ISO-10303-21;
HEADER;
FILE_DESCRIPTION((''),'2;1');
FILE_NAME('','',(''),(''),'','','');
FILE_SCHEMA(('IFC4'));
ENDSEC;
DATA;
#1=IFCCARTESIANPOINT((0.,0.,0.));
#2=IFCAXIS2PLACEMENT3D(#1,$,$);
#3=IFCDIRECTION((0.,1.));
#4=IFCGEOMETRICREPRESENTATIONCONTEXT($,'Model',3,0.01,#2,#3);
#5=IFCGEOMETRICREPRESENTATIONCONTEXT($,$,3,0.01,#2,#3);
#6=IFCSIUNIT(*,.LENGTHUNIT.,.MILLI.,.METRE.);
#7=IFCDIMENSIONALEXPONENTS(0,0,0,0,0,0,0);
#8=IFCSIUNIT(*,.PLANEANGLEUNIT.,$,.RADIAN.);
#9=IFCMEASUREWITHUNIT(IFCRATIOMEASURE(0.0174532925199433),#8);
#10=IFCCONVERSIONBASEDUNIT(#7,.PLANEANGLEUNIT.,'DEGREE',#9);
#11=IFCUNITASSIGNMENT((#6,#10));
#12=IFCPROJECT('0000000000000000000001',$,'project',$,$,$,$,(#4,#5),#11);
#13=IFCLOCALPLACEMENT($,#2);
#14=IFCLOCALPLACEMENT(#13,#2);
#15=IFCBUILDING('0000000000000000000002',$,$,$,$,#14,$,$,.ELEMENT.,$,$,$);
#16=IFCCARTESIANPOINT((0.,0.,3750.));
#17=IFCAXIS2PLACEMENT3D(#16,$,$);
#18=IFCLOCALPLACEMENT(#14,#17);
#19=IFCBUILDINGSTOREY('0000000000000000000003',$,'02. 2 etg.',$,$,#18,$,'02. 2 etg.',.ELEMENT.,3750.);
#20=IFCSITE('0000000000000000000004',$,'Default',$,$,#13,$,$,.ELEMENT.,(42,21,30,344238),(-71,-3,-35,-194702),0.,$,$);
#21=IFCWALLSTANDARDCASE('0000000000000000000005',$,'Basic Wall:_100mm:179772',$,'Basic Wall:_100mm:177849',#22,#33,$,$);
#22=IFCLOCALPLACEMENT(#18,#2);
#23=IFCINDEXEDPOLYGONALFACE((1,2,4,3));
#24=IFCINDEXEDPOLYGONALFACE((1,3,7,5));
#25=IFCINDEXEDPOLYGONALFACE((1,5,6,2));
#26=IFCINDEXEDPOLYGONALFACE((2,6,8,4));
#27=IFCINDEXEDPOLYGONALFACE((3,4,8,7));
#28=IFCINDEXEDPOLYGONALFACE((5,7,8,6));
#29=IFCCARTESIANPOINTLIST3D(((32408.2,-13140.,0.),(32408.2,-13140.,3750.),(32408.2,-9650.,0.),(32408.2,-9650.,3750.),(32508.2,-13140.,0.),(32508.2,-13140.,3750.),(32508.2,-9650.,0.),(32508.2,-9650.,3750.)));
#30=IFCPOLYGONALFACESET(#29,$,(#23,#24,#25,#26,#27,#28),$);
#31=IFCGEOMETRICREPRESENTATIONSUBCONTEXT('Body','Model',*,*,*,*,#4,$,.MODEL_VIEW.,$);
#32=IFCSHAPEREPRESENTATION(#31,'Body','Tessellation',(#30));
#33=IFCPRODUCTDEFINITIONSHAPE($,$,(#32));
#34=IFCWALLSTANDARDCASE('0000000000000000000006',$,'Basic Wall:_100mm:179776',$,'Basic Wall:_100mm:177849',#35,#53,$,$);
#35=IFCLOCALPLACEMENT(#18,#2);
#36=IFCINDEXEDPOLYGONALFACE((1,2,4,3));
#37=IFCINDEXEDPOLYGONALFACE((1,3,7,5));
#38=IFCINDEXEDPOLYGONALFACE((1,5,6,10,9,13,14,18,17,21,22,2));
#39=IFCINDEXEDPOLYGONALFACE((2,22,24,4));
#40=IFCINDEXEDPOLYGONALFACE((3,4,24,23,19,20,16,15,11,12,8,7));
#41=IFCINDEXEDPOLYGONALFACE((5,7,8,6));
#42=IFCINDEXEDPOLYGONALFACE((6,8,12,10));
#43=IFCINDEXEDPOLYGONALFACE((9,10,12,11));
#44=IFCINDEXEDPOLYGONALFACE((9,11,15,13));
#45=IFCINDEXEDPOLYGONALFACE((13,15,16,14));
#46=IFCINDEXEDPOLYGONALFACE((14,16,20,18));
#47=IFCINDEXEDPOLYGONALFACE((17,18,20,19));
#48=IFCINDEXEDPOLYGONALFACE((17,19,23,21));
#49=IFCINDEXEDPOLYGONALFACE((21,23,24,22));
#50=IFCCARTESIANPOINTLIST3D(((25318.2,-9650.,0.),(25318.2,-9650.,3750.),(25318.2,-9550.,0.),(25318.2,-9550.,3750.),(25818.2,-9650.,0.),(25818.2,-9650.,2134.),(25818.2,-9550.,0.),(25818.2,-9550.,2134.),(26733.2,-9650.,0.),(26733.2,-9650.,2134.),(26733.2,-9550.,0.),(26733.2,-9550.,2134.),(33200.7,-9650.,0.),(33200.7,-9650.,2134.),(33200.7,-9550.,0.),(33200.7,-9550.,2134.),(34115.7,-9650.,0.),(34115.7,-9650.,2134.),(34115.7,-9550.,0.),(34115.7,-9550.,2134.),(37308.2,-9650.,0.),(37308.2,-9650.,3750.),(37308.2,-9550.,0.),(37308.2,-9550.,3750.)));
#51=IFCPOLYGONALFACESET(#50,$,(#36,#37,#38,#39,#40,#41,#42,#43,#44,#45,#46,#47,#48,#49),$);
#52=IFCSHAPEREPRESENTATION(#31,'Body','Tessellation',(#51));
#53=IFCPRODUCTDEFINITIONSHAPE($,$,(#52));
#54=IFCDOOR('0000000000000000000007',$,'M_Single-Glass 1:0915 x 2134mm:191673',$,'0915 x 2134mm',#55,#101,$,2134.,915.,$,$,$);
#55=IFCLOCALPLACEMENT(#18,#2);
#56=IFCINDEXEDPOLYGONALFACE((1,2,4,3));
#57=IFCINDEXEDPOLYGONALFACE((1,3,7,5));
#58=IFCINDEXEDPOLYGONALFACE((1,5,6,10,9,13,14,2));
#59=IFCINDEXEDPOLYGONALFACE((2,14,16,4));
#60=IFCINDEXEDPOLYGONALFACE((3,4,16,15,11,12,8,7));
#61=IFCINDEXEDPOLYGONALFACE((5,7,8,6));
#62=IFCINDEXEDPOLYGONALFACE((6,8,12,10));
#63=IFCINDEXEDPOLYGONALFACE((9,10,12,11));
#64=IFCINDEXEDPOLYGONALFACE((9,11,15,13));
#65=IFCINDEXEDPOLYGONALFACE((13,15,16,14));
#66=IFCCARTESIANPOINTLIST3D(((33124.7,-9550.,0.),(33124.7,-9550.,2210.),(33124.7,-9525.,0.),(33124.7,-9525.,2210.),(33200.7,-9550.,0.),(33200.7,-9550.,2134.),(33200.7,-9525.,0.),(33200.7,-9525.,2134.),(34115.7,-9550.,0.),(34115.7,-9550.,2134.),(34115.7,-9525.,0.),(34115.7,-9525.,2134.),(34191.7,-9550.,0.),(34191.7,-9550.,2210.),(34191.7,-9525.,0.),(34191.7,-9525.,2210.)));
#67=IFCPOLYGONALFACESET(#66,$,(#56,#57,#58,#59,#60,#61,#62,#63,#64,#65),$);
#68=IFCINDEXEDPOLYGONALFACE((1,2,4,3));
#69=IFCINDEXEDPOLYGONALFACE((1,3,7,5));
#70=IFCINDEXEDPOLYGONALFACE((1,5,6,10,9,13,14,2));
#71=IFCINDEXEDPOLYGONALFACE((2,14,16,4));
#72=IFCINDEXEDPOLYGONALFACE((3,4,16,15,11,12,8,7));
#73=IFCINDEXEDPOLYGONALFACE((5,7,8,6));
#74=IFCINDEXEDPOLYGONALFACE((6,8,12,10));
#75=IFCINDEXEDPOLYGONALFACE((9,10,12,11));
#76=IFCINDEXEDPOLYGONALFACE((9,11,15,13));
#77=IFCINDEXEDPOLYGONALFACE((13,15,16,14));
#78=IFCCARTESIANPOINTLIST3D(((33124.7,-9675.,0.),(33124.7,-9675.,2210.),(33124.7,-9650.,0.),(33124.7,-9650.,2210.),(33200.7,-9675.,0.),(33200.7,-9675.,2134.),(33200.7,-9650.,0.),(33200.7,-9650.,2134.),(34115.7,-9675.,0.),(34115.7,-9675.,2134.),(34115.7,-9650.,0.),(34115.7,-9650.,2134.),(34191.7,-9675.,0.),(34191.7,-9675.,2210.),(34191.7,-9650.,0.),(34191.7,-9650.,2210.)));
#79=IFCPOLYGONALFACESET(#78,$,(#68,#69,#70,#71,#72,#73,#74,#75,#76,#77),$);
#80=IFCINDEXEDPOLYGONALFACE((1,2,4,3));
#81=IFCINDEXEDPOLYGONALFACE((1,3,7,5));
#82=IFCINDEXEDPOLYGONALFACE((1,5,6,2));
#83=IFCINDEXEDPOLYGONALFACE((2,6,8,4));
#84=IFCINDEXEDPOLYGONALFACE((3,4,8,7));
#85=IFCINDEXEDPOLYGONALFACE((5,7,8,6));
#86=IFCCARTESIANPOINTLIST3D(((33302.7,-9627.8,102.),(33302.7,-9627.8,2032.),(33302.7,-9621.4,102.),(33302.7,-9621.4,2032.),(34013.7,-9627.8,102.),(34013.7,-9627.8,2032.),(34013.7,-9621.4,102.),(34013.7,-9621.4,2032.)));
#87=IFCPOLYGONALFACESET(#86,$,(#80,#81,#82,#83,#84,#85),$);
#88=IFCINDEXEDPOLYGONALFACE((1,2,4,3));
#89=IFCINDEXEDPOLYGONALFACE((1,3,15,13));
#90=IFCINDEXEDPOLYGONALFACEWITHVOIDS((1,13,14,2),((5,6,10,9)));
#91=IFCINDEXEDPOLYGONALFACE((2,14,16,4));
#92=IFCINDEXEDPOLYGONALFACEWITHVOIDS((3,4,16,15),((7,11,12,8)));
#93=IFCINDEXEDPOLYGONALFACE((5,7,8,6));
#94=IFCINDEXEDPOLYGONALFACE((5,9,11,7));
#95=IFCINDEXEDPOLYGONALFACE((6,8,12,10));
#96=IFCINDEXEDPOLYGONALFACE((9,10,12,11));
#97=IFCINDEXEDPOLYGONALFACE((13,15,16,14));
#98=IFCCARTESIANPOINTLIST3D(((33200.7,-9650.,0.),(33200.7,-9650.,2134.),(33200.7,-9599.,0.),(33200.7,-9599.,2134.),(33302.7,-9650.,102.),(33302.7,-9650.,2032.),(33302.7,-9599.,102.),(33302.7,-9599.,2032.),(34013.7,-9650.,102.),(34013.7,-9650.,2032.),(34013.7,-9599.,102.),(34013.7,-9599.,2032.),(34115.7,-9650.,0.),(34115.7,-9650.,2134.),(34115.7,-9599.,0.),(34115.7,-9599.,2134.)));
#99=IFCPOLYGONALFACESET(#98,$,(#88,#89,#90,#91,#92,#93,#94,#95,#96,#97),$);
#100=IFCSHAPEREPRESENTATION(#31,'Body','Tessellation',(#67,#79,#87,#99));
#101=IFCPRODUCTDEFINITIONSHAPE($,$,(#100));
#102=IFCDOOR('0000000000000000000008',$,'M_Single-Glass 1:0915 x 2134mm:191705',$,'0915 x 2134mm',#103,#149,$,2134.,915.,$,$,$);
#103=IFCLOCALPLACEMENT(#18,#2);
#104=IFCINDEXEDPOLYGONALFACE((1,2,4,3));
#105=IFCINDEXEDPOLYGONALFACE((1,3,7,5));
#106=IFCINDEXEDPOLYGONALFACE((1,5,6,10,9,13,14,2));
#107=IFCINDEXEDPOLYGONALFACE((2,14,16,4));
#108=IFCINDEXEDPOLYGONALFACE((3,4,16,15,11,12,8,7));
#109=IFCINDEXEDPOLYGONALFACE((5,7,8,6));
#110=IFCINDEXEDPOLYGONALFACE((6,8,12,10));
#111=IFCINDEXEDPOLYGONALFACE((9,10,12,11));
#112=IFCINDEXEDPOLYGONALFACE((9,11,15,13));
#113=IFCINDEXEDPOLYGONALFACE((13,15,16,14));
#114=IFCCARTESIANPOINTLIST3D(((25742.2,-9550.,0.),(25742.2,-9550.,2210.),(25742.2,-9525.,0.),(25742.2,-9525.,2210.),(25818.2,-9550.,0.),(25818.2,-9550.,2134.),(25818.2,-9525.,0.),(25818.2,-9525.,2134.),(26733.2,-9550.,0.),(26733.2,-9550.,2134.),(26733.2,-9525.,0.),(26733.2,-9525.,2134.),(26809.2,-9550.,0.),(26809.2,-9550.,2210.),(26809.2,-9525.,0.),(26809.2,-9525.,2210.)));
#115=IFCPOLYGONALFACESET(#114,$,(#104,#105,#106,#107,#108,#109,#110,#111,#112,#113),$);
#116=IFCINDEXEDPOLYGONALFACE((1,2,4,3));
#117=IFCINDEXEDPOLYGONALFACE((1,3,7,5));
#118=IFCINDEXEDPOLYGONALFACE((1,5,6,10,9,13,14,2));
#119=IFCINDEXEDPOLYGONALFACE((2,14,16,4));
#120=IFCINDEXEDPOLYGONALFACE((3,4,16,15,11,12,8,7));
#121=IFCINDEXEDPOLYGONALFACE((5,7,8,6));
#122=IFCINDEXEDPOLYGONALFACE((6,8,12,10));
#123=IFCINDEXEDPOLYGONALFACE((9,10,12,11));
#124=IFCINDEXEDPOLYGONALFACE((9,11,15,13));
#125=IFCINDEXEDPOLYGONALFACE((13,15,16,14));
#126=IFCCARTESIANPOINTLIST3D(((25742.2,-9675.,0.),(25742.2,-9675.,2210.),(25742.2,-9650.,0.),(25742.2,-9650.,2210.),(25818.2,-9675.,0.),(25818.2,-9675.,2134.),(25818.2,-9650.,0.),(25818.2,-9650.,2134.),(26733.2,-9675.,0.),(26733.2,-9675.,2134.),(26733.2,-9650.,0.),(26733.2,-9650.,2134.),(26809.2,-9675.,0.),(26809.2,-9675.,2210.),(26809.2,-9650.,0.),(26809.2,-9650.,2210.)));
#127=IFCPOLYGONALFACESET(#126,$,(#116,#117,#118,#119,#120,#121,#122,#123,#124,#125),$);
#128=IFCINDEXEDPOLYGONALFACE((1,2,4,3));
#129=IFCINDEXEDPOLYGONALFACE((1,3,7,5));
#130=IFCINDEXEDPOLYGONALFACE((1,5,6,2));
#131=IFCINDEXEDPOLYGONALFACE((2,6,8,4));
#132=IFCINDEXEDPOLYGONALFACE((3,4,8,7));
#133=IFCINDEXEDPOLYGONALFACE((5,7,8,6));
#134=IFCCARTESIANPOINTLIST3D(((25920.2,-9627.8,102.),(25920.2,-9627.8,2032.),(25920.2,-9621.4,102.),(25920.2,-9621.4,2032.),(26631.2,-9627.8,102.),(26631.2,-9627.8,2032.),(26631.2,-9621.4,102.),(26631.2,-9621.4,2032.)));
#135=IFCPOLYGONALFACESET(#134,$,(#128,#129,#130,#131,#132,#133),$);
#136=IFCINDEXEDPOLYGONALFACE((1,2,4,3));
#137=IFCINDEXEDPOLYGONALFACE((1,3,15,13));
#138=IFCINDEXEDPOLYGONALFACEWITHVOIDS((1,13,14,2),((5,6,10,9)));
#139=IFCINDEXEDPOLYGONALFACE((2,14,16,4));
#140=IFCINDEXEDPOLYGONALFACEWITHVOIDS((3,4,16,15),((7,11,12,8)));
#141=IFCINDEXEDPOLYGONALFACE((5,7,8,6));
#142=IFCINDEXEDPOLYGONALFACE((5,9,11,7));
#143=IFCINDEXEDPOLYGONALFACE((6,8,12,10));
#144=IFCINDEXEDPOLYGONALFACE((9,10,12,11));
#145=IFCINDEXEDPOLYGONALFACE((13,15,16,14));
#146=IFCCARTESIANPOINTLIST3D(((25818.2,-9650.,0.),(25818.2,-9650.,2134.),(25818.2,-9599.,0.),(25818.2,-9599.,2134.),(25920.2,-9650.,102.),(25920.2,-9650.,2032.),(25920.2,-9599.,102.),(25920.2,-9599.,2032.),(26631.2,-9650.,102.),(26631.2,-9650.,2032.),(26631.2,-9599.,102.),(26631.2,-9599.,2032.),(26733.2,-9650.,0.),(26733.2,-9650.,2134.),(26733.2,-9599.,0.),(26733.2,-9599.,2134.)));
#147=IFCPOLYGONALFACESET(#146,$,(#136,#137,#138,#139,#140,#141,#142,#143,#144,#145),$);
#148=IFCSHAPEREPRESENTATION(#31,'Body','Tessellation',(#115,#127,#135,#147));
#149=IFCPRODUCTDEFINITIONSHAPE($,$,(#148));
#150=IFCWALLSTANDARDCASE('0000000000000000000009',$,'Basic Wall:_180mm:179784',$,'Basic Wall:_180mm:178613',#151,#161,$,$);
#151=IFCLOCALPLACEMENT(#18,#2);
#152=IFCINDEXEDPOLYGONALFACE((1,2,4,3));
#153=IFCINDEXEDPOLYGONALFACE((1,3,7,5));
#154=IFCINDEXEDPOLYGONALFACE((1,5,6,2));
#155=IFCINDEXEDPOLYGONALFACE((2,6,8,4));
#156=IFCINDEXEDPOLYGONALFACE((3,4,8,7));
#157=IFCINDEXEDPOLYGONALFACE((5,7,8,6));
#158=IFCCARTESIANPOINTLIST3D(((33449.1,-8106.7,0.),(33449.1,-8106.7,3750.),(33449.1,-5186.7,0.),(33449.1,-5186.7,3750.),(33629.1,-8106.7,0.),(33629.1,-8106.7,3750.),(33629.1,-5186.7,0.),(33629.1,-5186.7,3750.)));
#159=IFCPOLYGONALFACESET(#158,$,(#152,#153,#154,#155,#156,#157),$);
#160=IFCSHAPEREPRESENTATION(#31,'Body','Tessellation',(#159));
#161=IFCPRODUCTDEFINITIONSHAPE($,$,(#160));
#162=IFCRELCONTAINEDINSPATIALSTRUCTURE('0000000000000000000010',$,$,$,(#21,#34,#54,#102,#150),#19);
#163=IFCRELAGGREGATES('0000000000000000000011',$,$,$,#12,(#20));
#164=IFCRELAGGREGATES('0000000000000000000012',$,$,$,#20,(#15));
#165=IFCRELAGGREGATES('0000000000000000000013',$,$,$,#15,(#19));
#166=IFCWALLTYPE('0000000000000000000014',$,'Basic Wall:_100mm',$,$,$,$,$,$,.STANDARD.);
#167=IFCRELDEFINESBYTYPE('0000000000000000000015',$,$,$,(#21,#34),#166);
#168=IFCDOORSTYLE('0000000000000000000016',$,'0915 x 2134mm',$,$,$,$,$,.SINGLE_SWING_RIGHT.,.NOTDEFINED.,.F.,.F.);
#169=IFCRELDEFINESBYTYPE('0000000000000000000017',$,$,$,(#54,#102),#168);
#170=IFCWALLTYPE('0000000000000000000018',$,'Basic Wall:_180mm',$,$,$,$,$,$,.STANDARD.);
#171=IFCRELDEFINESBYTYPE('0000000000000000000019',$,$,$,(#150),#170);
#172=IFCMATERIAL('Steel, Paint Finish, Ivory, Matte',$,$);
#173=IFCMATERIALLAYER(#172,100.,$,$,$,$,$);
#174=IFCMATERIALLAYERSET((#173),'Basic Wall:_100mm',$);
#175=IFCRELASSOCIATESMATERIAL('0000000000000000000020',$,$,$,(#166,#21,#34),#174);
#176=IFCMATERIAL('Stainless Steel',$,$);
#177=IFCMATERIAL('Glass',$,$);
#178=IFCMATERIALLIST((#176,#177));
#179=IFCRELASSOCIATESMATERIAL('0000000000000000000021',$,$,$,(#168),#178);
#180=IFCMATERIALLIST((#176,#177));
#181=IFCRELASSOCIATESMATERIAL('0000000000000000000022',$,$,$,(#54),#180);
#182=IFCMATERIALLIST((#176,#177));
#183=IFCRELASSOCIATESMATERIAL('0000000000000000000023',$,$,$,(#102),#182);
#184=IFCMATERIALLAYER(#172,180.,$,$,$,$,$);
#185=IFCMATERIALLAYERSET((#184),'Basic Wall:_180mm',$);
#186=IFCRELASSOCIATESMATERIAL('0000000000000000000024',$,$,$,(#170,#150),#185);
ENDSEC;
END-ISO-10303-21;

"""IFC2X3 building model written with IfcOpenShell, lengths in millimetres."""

from ifc_helpers import new_model, entity, si_unit, converted_unit, direction, frame, frame_2d, origin, place, context, subcontext, project, spatial, polyline, rectangle, outline, extrude, source, transform, mapped, material, material_list, layer, layer_set, layer_usage, type_object, type_shapes, element, fill, save


model = new_model("IFC2X3")

# Units and contexts
model_context = context("Model", 3, precision=0.01, world=origin(), true_north=direction((0.0, 1.0)))
context_of_model = context(None, 3, precision=0.01, world=origin(), true_north=direction((0.0, 1.0)))
body_context = subcontext(model_context, "Body", "Model", "MODEL_VIEW")
ifc_project = project(units=[si_unit("LENGTHUNIT", "METRE", prefix="MILLI"), converted_unit("PLANEANGLEUNIT", "DEGREE", entity("IfcRatioMeasure", 0.0174532925199433), si_unit("PLANEANGLEUNIT", "RADIAN"), dimensions=[0, 0, 0, 0, 0, 0, 0])], contexts=[model_context, context_of_model])

# Site, building, storey
site_placement = place(None, origin())
site = spatial("IfcSite", under=ifc_project, at=site_placement, Name="Default", CompositionType="ELEMENT", RefLatitude=(42, 21, 30, 344238), RefLongitude=(-71, -3, -35, -194702), RefElevation=0.0)
building_placement = place(site_placement, origin())
building = spatial("IfcBuilding", under=site, at=building_placement, CompositionType="ELEMENT")
storey_placement = place(building_placement, frame((0.0, 0.0, 3750.0)))
storey = spatial("IfcBuildingStorey", under=building, at=storey_placement, Name="02. 2 etg.", LongName="02. 2 etg.", CompositionType="ELEMENT", Elevation=3750.0)

# Shared definitions
ifc_material_1 = material(Name="Glass")

# Shared definitions
ifc_material_2 = material(Name="Stainless Steel")

# Wall
ifc_material_3 = material(Name="Steel, Paint Finish, Ivory, Matte")
ifc_layer_1 = layer(ifc_material_3, 100.0)
ifc_layer_set_1 = layer_set([ifc_layer_1], Name="Basic Wall:_100mm")
ifc_layer_usage_1 = layer_usage(ifc_layer_set_1, "AXIS2", "POSITIVE", -50.0)
wall_type_1 = type_object("IfcWallType", Name="Basic Wall:_100mm", PredefinedType="STANDARD", material=ifc_layer_set_1)
wall_1_placement = place(storey_placement, frame((32458.2, -13140.0, 0.0), z_axis=(0.0, 0.0, 1.0), x_axis=(0.0, 1.0, 0.0)))
element("IfcWallStandardCase", 1, at=wall_1_placement, inside=storey, type_object=wall_type_1, material=ifc_layer_usage_1, Name="Basic Wall:_100mm:179772", ObjectType="Basic Wall:_100mm:177849", context=body_context, shape_type="SweptSolid", body=[
    extrude(rectangle(XDim=3490.0, YDim=100.0, at=frame_2d((1745.0, 0.0), x_axis=(-1.0, 0.0))), origin(), (0.0, 0.0, 1.0), 3750.0),
])

# Wall, openings, doors
ifc_layer_usage_2 = layer_usage(ifc_layer_set_1, "AXIS2", "POSITIVE", -50.0)
wall_2_placement = place(storey_placement, frame((25318.2, -9600.0, 0.0)))
wall_2 = element("IfcWallStandardCase", 2, at=wall_2_placement, inside=storey, type_object=wall_type_1, material=ifc_layer_usage_2, Name="Basic Wall:_100mm:179776", ObjectType="Basic Wall:_100mm:177849", context=body_context, shape_type="SweptSolid", body=[
    extrude(rectangle(XDim=11990.0, YDim=100.0, at=frame_2d((5995.0, 0.0), x_axis=(-1.0, 0.0))), origin(), (0.0, 0.0, 1.0), 3750.0),
])
opening_1_placement = place(wall_2_placement, frame((8797.5, 50.0, 0.0)))
opening_1 = element("IfcOpeningElement", 3, at=opening_1_placement, cuts=wall_2, ObjectType="Opening", context=body_context, shape_type="SweptSolid", body=[
    extrude(rectangle(XDim=915.0, YDim=2134.0, at=frame_2d((1067.0, 457.5), x_axis=(0.0, 1.0))), frame((0.0, 0.0, 0.0), z_axis=(0.0, -1.0, 0.0), x_axis=(0.0, 0.0, 1.0)), (0.0, 0.0, 1.0), 100.0),
])
opening_2_placement = place(wall_2_placement, frame((1415.0, 50.0, 0.0)))
opening_2 = element("IfcOpeningElement", 4, at=opening_2_placement, cuts=wall_2, ObjectType="Opening", context=body_context, shape_type="SweptSolid", body=[
    extrude(rectangle(XDim=915.0, YDim=2134.0, at=frame_2d((1067.0, 457.5), x_axis=(0.0, 1.0))), frame((0.0, 0.0, 0.0), z_axis=(0.0, -1.0, 0.0), x_axis=(0.0, 0.0, 1.0)), (0.0, 0.0, 1.0), 100.0),
])
ifc_material_list_1 = material_list([ifc_material_2, ifc_material_1])
ifc_material_list_2 = material_list([ifc_material_2, ifc_material_1])
door_style_1 = type_object("IfcDoorStyle", Name="0915 x 2134mm", ConstructionType="NOTDEFINED", OperationType="SINGLE_SWING_RIGHT", ParameterTakesPrecedence=False, Sizeable=False, material=ifc_material_list_2)
shared_shape_1 = source(origin(), body_context, "Body", "SweptSolid", [
    extrude(outline(polyline([(-457.5, -1048.0), (-457.5, 1086.0), (-533.5, 1086.0), (-533.5, -1124.0), (533.5, -1124.0), (533.5, 1086.0), (457.5, 1086.0), (457.5, -1048.0), (-457.5, -1048.0)])), frame((457.5, -25.0, 1086.0), z_axis=(0.0, -1.0, 0.0), x_axis=(-1.0, 0.0, 0.0)), (0.0, 0.0, -1.0), 25.0),
    extrude(outline(polyline([(-457.5, -1048.0), (-457.5, 1086.0), (-533.5, 1086.0), (-533.5, -1124.0), (533.5, -1124.0), (533.5, 1086.0), (457.5, 1086.0), (457.5, -1048.0), (-457.5, -1048.0)])), frame((457.5, 100.0, 1086.0), z_axis=(0.0, -1.0, 0.0), x_axis=(-1.0, 0.0, 0.0)), (0.0, 0.0, -1.0), 25.0),
    extrude(rectangle(XDim=6.3, YDim=711.0, at=frame_2d((0.0, 0.0), x_axis=(1.0, 0.0))), frame((457.5, 74.6, 102.0), z_axis=(0.0, 0.0, 1.0), x_axis=(0.0, 1.0, 0.0)), (0.0, 0.0, 1.0), 1930.0),
    extrude(outline(polyline([(-1067.0, -457.5), (1067.0, -457.5), (1067.0, 457.5), (-1067.0, 457.5), (-1067.0, -457.5)]), holes=[polyline([(-965.0, 355.5), (965.0, 355.5), (965.0, -355.5), (-965.0, -355.5), (-965.0, 355.5)])]), frame((457.5, 49.0, 1067.0), z_axis=(0.0, 1.0, 0.0), x_axis=(0.0, 0.0, -1.0)), (0.0, 0.0, 1.0), 51.0),
])
type_shapes(door_style_1, [shared_shape_1])
door_1_placement = place(opening_1_placement, frame((0.0, 0.0, 0.0), z_axis=(0.0, 0.0, 1.0), x_axis=(-1.0, 0.0, 0.0)))
door_1 = element("IfcDoor", 5, at=door_1_placement, inside=storey, type_object=door_style_1, material=ifc_material_list_1, Name="M_Single-Glass 1:0915 x 2134mm:191673", ObjectType="0915 x 2134mm", OverallHeight=2134.0, OverallWidth=915.0, context=body_context, shape_type="MappedRepresentation", body=[
    mapped(shared_shape_1, transform((0.0, 0.0, 0.0), scale=1.0)),
])
fill(opening_1, door_1)
ifc_material_list_3 = material_list([ifc_material_2, ifc_material_1])
door_2_placement = place(opening_2_placement, frame((0.0, 0.0, 0.0), z_axis=(0.0, 0.0, 1.0), x_axis=(-1.0, 0.0, 0.0)))
door_2 = element("IfcDoor", 6, at=door_2_placement, inside=storey, type_object=door_style_1, material=ifc_material_list_3, Name="M_Single-Glass 1:0915 x 2134mm:191705", ObjectType="0915 x 2134mm", OverallHeight=2134.0, OverallWidth=915.0, context=body_context, shape_type="MappedRepresentation", body=[
    mapped(shared_shape_1, transform((0.0, 0.0, 0.0), scale=1.0)),
])
fill(opening_2, door_2)

# Wall
ifc_layer_2 = layer(ifc_material_3, 180.0)
ifc_layer_set_2 = layer_set([ifc_layer_2], Name="Basic Wall:_180mm")
ifc_layer_usage_3 = layer_usage(ifc_layer_set_2, "AXIS2", "POSITIVE", -90.0)
wall_type_2 = type_object("IfcWallType", Name="Basic Wall:_180mm", PredefinedType="STANDARD", material=ifc_layer_set_2)
wall_3_placement = place(storey_placement, frame((33539.1, -8106.7, 0.0), z_axis=(0.0, 0.0, 1.0), x_axis=(0.0, 1.0, 0.0)))
element("IfcWallStandardCase", 7, at=wall_3_placement, inside=storey, type_object=wall_type_2, material=ifc_layer_usage_3, Name="Basic Wall:_180mm:179784", ObjectType="Basic Wall:_180mm:178613", context=body_context, shape_type="SweptSolid", body=[
    extrude(rectangle(XDim=2920.0, YDim=180.0, at=frame_2d((1460.0, 0.0), x_axis=(-1.0, 0.0))), origin(), (0.0, 0.0, 1.0), 3750.0),
])

save(model, "model.ifc")
